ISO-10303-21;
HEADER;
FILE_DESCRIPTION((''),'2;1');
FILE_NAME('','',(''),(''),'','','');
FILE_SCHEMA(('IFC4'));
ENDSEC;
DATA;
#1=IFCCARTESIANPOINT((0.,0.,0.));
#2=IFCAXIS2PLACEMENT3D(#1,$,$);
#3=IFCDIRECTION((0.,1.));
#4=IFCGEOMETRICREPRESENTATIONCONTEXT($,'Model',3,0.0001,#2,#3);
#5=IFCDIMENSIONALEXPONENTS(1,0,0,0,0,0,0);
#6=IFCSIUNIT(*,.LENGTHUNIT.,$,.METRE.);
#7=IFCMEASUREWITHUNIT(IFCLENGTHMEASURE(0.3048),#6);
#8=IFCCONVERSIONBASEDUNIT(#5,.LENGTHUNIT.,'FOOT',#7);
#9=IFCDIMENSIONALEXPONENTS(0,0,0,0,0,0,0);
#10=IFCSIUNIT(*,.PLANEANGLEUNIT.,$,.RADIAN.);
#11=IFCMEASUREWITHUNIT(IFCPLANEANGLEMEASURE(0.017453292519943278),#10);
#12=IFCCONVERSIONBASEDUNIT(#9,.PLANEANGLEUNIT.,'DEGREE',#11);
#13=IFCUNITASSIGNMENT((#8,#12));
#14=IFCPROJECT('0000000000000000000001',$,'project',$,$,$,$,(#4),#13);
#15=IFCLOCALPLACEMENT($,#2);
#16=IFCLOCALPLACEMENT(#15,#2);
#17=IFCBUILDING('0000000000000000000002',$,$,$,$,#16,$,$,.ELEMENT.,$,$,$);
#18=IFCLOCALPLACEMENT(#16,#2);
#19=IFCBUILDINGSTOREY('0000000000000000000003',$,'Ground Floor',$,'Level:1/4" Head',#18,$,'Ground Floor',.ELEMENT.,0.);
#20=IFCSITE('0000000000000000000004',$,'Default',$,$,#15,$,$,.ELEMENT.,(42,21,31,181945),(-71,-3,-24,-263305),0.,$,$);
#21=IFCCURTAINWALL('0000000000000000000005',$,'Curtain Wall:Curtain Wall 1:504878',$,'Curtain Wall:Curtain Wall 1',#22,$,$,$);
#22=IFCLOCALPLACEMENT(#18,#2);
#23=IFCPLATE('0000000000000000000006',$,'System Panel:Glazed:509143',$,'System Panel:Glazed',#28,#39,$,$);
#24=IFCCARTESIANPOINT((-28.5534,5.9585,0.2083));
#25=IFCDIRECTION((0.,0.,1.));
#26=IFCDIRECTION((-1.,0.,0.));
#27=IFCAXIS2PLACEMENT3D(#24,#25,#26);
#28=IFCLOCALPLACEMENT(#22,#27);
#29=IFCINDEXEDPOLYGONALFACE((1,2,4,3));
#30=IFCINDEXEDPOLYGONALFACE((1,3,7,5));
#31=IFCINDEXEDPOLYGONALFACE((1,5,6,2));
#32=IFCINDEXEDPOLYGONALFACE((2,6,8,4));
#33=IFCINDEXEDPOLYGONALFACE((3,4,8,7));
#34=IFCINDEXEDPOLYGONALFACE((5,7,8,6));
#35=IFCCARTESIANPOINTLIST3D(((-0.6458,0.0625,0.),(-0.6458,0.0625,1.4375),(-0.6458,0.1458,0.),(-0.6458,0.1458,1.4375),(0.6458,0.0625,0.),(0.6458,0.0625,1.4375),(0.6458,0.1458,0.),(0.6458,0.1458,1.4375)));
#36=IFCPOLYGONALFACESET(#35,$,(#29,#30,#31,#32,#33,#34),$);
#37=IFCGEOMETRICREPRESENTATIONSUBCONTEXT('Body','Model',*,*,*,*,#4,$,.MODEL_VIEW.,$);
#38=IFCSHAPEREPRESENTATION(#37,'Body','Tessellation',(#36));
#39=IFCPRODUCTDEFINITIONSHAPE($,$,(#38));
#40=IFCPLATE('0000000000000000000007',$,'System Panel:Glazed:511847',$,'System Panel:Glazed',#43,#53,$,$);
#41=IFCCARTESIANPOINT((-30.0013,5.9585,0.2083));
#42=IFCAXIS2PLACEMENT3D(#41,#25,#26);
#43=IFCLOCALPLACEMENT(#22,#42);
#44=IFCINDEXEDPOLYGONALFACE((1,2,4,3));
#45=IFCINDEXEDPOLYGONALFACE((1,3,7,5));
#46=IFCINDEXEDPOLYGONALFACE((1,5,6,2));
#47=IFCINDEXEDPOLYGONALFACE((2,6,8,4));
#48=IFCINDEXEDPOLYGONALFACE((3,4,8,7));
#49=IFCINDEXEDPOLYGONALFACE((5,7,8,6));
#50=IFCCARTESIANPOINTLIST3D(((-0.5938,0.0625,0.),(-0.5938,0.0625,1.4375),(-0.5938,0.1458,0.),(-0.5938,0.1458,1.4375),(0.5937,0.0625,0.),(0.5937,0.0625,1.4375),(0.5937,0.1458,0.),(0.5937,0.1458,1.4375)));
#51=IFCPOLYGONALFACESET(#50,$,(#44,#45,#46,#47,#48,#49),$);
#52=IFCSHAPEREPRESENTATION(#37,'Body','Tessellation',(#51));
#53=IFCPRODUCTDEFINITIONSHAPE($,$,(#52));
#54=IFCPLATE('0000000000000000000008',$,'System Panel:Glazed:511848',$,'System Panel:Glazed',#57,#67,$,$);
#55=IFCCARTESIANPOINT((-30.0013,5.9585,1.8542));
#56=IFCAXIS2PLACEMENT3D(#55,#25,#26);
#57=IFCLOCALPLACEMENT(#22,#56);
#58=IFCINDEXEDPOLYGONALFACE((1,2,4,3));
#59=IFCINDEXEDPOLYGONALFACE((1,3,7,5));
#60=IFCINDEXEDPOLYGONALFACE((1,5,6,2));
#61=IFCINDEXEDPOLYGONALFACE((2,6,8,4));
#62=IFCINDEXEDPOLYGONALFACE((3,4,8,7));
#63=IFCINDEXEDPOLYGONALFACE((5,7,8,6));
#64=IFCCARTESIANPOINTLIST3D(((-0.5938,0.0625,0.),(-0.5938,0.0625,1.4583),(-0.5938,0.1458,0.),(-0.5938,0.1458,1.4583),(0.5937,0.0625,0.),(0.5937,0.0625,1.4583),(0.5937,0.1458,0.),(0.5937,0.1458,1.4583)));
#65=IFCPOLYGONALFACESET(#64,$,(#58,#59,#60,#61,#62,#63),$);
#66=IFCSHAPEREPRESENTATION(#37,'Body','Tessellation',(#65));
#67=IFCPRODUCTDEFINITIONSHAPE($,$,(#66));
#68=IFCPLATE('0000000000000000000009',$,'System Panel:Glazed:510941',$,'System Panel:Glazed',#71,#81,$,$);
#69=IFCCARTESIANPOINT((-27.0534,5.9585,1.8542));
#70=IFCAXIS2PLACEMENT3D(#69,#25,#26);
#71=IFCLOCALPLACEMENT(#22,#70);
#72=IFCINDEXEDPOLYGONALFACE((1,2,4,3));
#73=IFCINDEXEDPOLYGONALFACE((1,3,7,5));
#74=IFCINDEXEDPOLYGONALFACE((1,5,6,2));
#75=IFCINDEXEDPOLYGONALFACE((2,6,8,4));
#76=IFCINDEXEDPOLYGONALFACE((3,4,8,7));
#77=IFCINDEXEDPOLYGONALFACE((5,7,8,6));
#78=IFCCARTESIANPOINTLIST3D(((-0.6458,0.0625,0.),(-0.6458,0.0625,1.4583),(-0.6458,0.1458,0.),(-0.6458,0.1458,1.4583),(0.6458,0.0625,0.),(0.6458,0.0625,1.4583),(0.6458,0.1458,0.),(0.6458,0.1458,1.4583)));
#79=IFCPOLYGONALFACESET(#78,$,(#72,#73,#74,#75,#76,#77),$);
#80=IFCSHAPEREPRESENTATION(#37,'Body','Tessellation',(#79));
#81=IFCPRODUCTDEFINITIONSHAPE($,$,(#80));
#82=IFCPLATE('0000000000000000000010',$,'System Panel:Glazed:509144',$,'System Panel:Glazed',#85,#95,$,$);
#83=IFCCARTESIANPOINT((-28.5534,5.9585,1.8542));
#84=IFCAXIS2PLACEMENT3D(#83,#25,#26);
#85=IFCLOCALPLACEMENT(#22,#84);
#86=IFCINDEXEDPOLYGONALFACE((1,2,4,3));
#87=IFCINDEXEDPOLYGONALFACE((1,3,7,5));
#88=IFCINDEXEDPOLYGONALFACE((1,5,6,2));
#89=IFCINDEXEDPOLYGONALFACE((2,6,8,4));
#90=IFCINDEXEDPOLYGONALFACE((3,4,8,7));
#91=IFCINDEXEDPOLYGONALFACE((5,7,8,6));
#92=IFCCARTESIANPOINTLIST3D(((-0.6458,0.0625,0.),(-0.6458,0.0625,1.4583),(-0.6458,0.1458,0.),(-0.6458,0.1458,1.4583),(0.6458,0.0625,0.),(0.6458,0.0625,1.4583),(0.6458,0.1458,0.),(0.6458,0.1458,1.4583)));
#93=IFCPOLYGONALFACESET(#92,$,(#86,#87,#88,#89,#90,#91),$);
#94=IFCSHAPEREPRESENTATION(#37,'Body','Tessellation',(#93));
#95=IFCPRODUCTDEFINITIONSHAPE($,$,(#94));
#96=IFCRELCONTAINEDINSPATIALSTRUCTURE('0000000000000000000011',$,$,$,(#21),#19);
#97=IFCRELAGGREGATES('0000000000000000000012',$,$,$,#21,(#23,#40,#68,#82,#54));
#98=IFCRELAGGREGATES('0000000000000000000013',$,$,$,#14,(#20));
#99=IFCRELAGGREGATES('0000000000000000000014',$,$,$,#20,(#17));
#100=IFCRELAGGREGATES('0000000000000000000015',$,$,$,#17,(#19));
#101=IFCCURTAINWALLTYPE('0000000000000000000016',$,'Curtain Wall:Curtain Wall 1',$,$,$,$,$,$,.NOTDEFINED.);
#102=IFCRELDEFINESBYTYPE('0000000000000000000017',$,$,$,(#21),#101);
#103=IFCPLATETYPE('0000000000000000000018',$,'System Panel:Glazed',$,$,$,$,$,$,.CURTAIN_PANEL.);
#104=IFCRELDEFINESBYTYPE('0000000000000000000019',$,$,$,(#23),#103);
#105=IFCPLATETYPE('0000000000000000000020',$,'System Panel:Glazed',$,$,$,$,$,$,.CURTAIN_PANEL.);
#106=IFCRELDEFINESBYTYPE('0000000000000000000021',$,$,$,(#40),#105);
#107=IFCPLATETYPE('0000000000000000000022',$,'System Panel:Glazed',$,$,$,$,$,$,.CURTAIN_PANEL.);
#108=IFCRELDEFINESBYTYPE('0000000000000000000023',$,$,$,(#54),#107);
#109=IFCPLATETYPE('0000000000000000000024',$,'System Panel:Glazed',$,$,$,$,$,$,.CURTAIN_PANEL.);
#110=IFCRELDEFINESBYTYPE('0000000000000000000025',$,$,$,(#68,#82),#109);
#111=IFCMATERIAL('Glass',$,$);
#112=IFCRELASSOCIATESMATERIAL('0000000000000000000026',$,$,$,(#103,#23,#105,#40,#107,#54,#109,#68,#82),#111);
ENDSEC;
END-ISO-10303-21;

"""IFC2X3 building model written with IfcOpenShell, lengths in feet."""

from ifc_helpers import new_model, entity, si_unit, converted_unit, direction, frame, frame_2d, origin, place, context, subcontext, project, spatial, rectangle, extrude, source, transform, mapped, material, type_object, type_shapes, element, aggregate, save


model = new_model("IFC2X3")

# Units and contexts
model_context = context("Model", 3, precision=0.0001, world=origin(), true_north=direction((0.0, 1.0)))
body_context = subcontext(model_context, "Body", "Model", "MODEL_VIEW")
ifc_project = project(units=[converted_unit("LENGTHUNIT", "FOOT", entity("IfcLengthMeasure", 0.3048), si_unit("LENGTHUNIT", "METRE"), dimensions=[1, 0, 0, 0, 0, 0, 0]), converted_unit("PLANEANGLEUNIT", "DEGREE", entity("IfcPlaneAngleMeasure", 0.017453292519943278), si_unit("PLANEANGLEUNIT", "RADIAN"), dimensions=[0, 0, 0, 0, 0, 0, 0])], contexts=[model_context])

# Site, building, storey
site_placement = place(None, origin())
site = spatial("IfcSite", under=ifc_project, at=site_placement, Name="Default", CompositionType="ELEMENT", RefLatitude=(42, 21, 31, 181945), RefLongitude=(-71, -3, -24, -263305), RefElevation=0.0)
building_placement = place(site_placement, origin())
building = spatial("IfcBuilding", under=site, at=building_placement, CompositionType="ELEMENT")
storey_placement = place(building_placement, origin())
storey = spatial("IfcBuildingStorey", under=building, at=storey_placement, Name="Ground Floor", ObjectType="Level:1/4\" Head", LongName="Ground Floor", CompositionType="ELEMENT", Elevation=0.0)

# Curtain wall, plates
curtain_wall_type = type_object("IfcCurtainWallType", Name="Curtain Wall:Curtain Wall 1", PredefinedType="NOTDEFINED")
curtain_wall_placement = place(storey_placement, origin())
curtain_wall = element("IfcCurtainWall", 1, at=curtain_wall_placement, inside=storey, type_object=curtain_wall_type, Name="Curtain Wall:Curtain Wall 1:504878", ObjectType="Curtain Wall:Curtain Wall 1")
ifc_material_1 = material(Name="Glass")
plate_type_1 = type_object("IfcPlateType", Name="System Panel:Glazed", PredefinedType="CURTAIN_PANEL", material=ifc_material_1)
shared_shape_1 = source(origin(), body_context, "Body", "SweptSolid", [
    extrude(rectangle(XDim=0.0833, YDim=1.2917, at=frame_2d((0.0, 0.0), x_axis=(1.0, 0.0))), frame((0.0, 0.1042, 0.0), z_axis=(0.0, 0.0, 1.0), x_axis=(0.0, 1.0, 0.0)), (0.0, 0.0, 1.0), 1.4375),
])
type_shapes(plate_type_1, [shared_shape_1])
plate_1_placement = place(curtain_wall_placement, frame((-28.5534, 5.9585, 0.2083), z_axis=(0.0, 0.0, 1.0), x_axis=(-1.0, 0.0, 0.0)))
plate_1 = element("IfcPlate", 2, at=plate_1_placement, type_object=plate_type_1, material=ifc_material_1, Name="System Panel:Glazed:509143", ObjectType="System Panel:Glazed", context=body_context, shape_type="MappedRepresentation", body=[
    mapped(shared_shape_1, transform((0.0, 0.0, 0.0), scale=1.0)),
])
plate_type_2 = type_object("IfcPlateType", Name="System Panel:Glazed", PredefinedType="CURTAIN_PANEL", material=ifc_material_1)
shared_shape_2 = source(origin(), body_context, "Body", "SweptSolid", [
    extrude(rectangle(XDim=0.0833, YDim=1.1875, at=frame_2d((0.0, 0.0), x_axis=(1.0, 0.0))), frame((0.0, 0.1042, 0.0), z_axis=(0.0, 0.0, 1.0), x_axis=(0.0, 1.0, 0.0)), (0.0, 0.0, 1.0), 1.4375),
])
type_shapes(plate_type_2, [shared_shape_2])
plate_2_placement = place(curtain_wall_placement, frame((-30.0013, 5.9585, 0.2083), z_axis=(0.0, 0.0, 1.0), x_axis=(-1.0, 0.0, 0.0)))
plate_2 = element("IfcPlate", 3, at=plate_2_placement, type_object=plate_type_2, material=ifc_material_1, Name="System Panel:Glazed:511847", ObjectType="System Panel:Glazed", context=body_context, shape_type="MappedRepresentation", body=[
    mapped(shared_shape_2, transform((0.0, 0.0, 0.0), scale=1.0)),
])
plate_type_3 = type_object("IfcPlateType", Name="System Panel:Glazed", PredefinedType="CURTAIN_PANEL", material=ifc_material_1)
shared_shape_3 = source(origin(), body_context, "Body", "SweptSolid", [
    extrude(rectangle(XDim=0.0833, YDim=1.1875, at=frame_2d((0.0, 0.0), x_axis=(1.0, 0.0))), frame((0.0, 0.1042, 0.0), z_axis=(0.0, 0.0, 1.0), x_axis=(0.0, 1.0, 0.0)), (0.0, 0.0, 1.0), 1.4583),
])
type_shapes(plate_type_3, [shared_shape_3])
plate_3_placement = place(curtain_wall_placement, frame((-30.0013, 5.9585, 1.8542), z_axis=(0.0, 0.0, 1.0), x_axis=(-1.0, 0.0, 0.0)))
plate_3 = element("IfcPlate", 4, at=plate_3_placement, type_object=plate_type_3, material=ifc_material_1, Name="System Panel:Glazed:511848", ObjectType="System Panel:Glazed", context=body_context, shape_type="MappedRepresentation", body=[
    mapped(shared_shape_3, transform((0.0, 0.0, 0.0), scale=1.0)),
])
plate_type_4 = type_object("IfcPlateType", Name="System Panel:Glazed", PredefinedType="CURTAIN_PANEL", material=ifc_material_1)
shared_shape_4 = source(origin(), body_context, "Body", "SweptSolid", [
    extrude(rectangle(XDim=0.0833, YDim=1.2917, at=frame_2d((0.0, 0.0), x_axis=(1.0, 0.0))), frame((0.0, 0.1042, 0.0), z_axis=(0.0, 0.0, 1.0), x_axis=(0.0, 1.0, 0.0)), (0.0, 0.0, 1.0), 1.4583),
])
type_shapes(plate_type_4, [shared_shape_4])
plate_4_placement = place(curtain_wall_placement, frame((-27.0534, 5.9585, 1.8542), z_axis=(0.0, 0.0, 1.0), x_axis=(-1.0, 0.0, 0.0)))
plate_4 = element("IfcPlate", 5, at=plate_4_placement, type_object=plate_type_4, material=ifc_material_1, Name="System Panel:Glazed:510941", ObjectType="System Panel:Glazed", context=body_context, shape_type="MappedRepresentation", body=[
    mapped(shared_shape_4, transform((0.0, 0.0, 0.0), scale=1.0)),
])
plate_5_placement = place(curtain_wall_placement, frame((-28.5534, 5.9585, 1.8542), z_axis=(0.0, 0.0, 1.0), x_axis=(-1.0, 0.0, 0.0)))
plate_5 = element("IfcPlate", 6, at=plate_5_placement, type_object=plate_type_4, material=ifc_material_1, Name="System Panel:Glazed:509144", ObjectType="System Panel:Glazed", context=body_context, shape_type="MappedRepresentation", body=[
    mapped(shared_shape_4, transform((0.0, 0.0, 0.0), scale=1.0)),
])
aggregate(curtain_wall, [plate_1, plate_2, plate_4, plate_5, plate_3])

save(model, "model.ifc")
